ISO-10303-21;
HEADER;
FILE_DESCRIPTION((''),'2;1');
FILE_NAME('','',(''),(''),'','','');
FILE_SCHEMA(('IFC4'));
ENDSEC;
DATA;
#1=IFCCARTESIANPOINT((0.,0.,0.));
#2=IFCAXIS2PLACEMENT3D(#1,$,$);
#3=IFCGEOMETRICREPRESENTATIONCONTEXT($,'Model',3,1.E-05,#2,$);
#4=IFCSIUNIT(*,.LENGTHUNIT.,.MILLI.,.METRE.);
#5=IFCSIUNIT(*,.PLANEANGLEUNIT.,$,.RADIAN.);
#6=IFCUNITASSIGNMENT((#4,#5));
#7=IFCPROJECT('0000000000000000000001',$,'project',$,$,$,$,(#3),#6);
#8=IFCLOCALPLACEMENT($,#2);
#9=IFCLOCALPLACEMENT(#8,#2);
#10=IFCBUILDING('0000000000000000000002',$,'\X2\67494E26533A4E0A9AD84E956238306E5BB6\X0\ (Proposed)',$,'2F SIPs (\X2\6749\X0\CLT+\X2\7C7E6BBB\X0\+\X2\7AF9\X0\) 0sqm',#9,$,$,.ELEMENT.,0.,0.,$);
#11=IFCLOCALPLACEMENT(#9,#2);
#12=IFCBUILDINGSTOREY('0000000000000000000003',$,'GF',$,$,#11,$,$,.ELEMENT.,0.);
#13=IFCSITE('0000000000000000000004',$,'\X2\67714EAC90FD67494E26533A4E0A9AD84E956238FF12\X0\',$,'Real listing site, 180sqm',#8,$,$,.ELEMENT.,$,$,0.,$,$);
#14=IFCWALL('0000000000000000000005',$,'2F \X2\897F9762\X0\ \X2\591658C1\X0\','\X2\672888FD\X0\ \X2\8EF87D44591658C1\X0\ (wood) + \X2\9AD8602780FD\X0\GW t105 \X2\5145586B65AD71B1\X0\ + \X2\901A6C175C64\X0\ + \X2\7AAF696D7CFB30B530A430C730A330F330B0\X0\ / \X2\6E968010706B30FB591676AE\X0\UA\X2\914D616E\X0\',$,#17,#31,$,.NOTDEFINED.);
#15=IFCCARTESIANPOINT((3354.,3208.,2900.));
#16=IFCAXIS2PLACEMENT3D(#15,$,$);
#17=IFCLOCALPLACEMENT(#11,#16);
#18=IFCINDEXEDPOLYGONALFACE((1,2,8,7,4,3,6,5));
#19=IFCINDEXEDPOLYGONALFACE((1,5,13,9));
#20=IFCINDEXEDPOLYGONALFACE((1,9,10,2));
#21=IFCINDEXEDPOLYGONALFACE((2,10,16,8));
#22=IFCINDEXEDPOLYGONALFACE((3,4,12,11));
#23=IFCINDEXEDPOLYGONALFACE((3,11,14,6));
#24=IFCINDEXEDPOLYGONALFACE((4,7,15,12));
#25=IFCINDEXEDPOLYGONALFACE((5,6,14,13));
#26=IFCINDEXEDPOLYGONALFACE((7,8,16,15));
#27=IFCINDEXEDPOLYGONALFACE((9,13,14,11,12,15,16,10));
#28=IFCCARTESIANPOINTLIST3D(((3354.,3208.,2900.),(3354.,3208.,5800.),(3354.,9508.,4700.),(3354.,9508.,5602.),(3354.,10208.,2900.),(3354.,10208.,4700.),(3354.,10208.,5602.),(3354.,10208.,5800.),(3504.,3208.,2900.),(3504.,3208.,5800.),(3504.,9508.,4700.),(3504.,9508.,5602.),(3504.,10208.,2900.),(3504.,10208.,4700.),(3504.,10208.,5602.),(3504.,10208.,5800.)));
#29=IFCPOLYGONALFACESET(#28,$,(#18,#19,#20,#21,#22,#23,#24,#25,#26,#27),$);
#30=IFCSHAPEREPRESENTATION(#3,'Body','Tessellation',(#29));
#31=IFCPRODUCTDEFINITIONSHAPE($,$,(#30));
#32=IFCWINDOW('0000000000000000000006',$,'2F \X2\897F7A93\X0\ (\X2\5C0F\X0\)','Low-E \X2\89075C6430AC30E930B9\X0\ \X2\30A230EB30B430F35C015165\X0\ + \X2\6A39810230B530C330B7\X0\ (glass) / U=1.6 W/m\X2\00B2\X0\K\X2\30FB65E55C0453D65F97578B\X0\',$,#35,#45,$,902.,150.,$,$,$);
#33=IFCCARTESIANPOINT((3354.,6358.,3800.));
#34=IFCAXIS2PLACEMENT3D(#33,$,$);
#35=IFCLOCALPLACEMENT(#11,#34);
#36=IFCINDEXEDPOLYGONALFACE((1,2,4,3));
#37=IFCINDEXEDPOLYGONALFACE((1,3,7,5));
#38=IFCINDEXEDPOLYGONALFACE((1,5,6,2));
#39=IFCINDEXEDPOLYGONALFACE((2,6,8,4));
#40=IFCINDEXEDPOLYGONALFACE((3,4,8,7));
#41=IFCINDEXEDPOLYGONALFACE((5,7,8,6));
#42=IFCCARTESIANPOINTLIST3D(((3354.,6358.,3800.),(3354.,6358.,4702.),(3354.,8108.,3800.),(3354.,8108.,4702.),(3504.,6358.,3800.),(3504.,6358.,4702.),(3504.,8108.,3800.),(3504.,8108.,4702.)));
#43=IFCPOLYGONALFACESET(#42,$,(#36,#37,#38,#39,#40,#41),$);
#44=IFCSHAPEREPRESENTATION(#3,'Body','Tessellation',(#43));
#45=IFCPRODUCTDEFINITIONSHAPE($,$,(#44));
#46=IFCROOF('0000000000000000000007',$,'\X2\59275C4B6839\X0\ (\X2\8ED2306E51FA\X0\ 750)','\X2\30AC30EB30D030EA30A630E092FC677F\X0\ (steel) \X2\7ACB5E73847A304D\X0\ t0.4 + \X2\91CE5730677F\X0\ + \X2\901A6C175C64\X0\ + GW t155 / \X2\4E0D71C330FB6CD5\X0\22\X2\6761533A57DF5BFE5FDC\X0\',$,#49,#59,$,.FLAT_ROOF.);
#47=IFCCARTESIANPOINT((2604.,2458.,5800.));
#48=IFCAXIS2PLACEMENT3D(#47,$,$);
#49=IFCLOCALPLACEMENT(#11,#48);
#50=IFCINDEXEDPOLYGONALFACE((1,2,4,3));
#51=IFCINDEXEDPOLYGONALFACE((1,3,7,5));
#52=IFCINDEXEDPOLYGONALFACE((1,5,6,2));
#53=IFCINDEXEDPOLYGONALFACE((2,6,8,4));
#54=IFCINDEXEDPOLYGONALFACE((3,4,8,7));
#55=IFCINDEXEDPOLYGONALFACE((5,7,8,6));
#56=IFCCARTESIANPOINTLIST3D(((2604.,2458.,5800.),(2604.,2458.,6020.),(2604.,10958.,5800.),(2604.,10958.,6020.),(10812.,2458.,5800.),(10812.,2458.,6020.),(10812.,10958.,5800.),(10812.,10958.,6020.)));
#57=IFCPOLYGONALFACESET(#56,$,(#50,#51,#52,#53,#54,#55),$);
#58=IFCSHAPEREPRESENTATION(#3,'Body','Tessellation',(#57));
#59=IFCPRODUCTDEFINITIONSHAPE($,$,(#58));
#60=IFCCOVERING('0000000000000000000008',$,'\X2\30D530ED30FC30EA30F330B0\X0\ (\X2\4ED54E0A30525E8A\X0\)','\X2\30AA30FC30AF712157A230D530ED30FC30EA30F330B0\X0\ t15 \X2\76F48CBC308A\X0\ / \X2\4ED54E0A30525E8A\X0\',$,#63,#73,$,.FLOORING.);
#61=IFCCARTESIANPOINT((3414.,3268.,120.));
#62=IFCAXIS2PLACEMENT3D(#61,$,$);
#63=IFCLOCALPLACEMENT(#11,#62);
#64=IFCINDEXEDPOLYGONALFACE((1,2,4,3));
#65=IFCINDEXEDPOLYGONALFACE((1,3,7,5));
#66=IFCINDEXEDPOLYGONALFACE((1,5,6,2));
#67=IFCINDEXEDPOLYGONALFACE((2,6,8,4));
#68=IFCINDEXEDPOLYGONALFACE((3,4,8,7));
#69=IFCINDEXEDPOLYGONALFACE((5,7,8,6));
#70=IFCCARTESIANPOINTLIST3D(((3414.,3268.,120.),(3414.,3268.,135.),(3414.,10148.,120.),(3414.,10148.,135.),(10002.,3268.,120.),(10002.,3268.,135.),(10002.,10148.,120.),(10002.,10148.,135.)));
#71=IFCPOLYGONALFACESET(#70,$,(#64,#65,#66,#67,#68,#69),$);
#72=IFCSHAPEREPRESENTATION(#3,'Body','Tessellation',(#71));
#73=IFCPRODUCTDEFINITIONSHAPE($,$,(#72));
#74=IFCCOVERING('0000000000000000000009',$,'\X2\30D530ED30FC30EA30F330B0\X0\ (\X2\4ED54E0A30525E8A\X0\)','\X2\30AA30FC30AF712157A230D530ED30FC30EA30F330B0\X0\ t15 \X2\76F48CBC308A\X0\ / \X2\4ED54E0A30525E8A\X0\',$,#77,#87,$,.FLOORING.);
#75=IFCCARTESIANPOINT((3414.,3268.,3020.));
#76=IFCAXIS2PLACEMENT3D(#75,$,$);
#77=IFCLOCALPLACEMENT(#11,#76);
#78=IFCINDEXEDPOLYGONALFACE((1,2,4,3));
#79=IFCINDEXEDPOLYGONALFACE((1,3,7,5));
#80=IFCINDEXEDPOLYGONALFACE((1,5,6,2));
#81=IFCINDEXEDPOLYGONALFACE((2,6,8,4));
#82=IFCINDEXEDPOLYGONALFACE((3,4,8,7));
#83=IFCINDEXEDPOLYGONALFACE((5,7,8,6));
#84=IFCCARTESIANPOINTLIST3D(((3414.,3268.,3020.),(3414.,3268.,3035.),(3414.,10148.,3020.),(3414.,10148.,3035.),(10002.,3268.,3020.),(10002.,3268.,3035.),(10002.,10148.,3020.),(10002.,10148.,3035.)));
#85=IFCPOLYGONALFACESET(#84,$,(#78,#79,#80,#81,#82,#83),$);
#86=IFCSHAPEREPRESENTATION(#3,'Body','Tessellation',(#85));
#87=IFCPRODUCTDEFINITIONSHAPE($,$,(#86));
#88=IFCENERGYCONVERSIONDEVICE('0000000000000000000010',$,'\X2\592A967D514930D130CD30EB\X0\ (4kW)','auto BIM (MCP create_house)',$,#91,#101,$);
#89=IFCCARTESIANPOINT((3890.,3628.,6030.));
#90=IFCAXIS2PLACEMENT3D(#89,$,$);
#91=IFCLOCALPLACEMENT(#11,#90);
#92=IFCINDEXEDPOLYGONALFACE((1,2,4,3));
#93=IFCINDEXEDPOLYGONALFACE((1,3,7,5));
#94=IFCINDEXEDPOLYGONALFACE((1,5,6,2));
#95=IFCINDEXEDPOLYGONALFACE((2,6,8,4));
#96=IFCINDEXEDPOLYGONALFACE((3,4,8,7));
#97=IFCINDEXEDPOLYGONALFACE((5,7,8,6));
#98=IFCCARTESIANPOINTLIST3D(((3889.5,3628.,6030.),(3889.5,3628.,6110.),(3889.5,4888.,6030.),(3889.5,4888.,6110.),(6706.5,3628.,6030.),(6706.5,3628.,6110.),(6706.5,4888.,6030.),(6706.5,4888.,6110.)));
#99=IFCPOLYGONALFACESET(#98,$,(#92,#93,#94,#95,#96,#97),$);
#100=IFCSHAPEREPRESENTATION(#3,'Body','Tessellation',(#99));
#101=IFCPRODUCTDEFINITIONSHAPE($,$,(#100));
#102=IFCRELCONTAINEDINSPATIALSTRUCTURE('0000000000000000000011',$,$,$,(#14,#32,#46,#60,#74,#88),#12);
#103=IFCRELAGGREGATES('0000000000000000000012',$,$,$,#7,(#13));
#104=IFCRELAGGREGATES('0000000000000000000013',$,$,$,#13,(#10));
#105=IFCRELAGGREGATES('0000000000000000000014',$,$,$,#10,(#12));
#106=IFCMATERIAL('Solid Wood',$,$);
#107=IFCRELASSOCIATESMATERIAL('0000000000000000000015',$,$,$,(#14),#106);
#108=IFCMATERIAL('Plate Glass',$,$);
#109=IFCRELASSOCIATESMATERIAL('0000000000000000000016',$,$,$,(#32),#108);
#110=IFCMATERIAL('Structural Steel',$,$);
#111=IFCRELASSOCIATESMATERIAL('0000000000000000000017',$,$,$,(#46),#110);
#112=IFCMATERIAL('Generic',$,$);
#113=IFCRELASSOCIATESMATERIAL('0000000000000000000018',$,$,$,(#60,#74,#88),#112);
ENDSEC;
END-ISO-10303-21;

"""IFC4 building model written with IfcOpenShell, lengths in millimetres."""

from ifc_helpers import new_model, si_unit, frame, frame_2d, origin, place, context, project, spatial, rectangle, extrude, material, element, fill, save


model = new_model("IFC4")

# Units and contexts
model_context = context("Model", 3, precision=1e-05, world=origin())
ifc_project = project(units=[si_unit("LENGTHUNIT", "METRE", prefix="MILLI"), si_unit("PLANEANGLEUNIT", "RADIAN")], contexts=[model_context])

# Site, building, storey
site_placement = place(None, origin())
site = spatial("IfcSite", under=ifc_project, at=site_placement, Name="東京都杉並区上高井戸２", ObjectType="Real listing site, 180sqm", CompositionType="ELEMENT", RefElevation=0.0)
building_placement = place(site_placement, origin())
building = spatial("IfcBuilding", under=site, at=building_placement, Name="杉並区上高井戸の家 (Proposed)", ObjectType="2F SIPs (杉CLT+籾殻+竹) 0sqm", CompositionType="ELEMENT", ElevationOfRefHeight=0.0, ElevationOfTerrain=0.0)
storey_placement = place(building_placement, origin())
storey = spatial("IfcBuildingStorey", under=building, at=storey_placement, Name="GF", CompositionType="ELEMENT", Elevation=0.0)

# Shared definitions
ifc_material_1 = material(Name="Solid Wood")

# Shared definitions
ifc_material_2 = material(Name="Plate Glass")

# Wall, opening, window
wall_1_placement = place(storey_placement, frame((3354.0, 3208.0, 2900.0)))
wall_1 = element("IfcWall", 1, at=wall_1_placement, inside=storey, material=ifc_material_1, Name="2F 西面 外壁", Description="木製 軸組外壁 (wood) + 高性能GW t105 充填断熱 + 通気層 + 窯業系サイディング / 準耐火・外皮UA配慮", PredefinedType="NOTDEFINED", context=model_context, shape_type="SweptSolid", body=[
    extrude(rectangle(XDim=150.0, YDim=7000.0, at=frame_2d((75.0, 3500.0))), frame((3354.0, 3208.0, 2900.0)), (0.0, 0.0, 1.0), 2900.0),
])
opening_1_placement = place(storey_placement, frame((3354.0, 6358.0, 3800.0)))
opening_1 = element("IfcOpeningElement", 2, at=opening_1_placement, cuts=wall_1, PredefinedType="NOTDEFINED", context=model_context, shape_type="SweptSolid", body=[
    extrude(rectangle(XDim=150.0, YDim=1750.0, at=frame_2d((75.0, 875.0))), frame((3354.0, 6358.0, 3800.0)), (0.0, 0.0, 1.0), 902.0),
])
window_1_placement = place(storey_placement, frame((3354.0, 6358.0, 3800.0)))
window_1 = element("IfcWindow", 3, at=window_1_placement, inside=storey, material=ifc_material_2, Name="2F 西窓 (小)", Description="Low-E 複層ガラス アルゴン封入 + 樹脂サッシ (glass) / U=1.6 W/m²K・日射取得型", OverallHeight=902.0, OverallWidth=150.0, context=model_context, shape_type="SweptSolid", body=[
    extrude(rectangle(XDim=150.0, YDim=1750.0, at=frame_2d((75.0, 875.0))), frame((3354.0, 6358.0, 3800.0)), (0.0, 0.0, 1.0), 902.0),
])
fill(opening_1, window_1)

# Roof
ifc_material_3 = material(Name="Structural Steel")
roof_placement = place(storey_placement, frame((2604.0, 2458.0, 5800.0)))
element("IfcRoof", 4, at=roof_placement, inside=storey, material=ifc_material_3, Name="大屋根 (軒の出 750)", Description="ガルバリウム鋼板 (steel) 立平葺き t0.4 + 野地板 + 通気層 + GW t155 / 不燃・法22条区域対応", PredefinedType="FLAT_ROOF", context=model_context, shape_type="SweptSolid", body=[
    extrude(rectangle(XDim=8208.0, YDim=8500.0, at=frame_2d((4104.0, 4250.0))), frame((2604.0, 2458.0, 5800.0)), (0.0, 0.0, 1.0), 220.0),
])

# Coverings
ifc_material_4 = material(Name="Generic")
covering_1_placement = place(storey_placement, frame((3414.0, 3268.0, 120.0)))
element("IfcCovering", 5, at=covering_1_placement, inside=storey, material=ifc_material_4, Name="フローリング (仕上げ床)", Description="オーク無垢フローリング t15 直貼り / 仕上げ床", PredefinedType="FLOORING", context=model_context, shape_type="SweptSolid", body=[
    extrude(rectangle(XDim=6588.0, YDim=6880.0, at=frame_2d((3294.0, 3440.0))), frame((3414.0, 3268.0, 120.0)), (0.0, 0.0, 1.0), 15.0),
])
covering_2_placement = place(storey_placement, frame((3414.0, 3268.0, 3020.0)))
element("IfcCovering", 6, at=covering_2_placement, inside=storey, material=ifc_material_4, Name="フローリング (仕上げ床)", Description="オーク無垢フローリング t15 直貼り / 仕上げ床", PredefinedType="FLOORING", context=model_context, shape_type="SweptSolid", body=[
    extrude(rectangle(XDim=6588.0, YDim=6880.0, at=frame_2d((3294.0, 3440.0))), frame((3414.0, 3268.0, 3020.0)), (0.0, 0.0, 1.0), 15.0),
])

# Energy conversion device
energy_conversion_device_placement = place(storey_placement, frame((3890.0, 3628.0, 6030.0)))
element("IfcEnergyConversionDevice", 7, at=energy_conversion_device_placement, inside=storey, material=ifc_material_4, Name="太陽光パネル (4kW)", Description="auto BIM (MCP create_house)", context=model_context, shape_type="SweptSolid", body=[
    extrude(rectangle(XDim=2817.0, YDim=1260.0, at=frame_2d((1408.0, 630.0))), frame((3890.0, 3628.0, 6030.0)), (0.0, 0.0, 1.0), 80.0),
])

save(model, "model.ifc")
